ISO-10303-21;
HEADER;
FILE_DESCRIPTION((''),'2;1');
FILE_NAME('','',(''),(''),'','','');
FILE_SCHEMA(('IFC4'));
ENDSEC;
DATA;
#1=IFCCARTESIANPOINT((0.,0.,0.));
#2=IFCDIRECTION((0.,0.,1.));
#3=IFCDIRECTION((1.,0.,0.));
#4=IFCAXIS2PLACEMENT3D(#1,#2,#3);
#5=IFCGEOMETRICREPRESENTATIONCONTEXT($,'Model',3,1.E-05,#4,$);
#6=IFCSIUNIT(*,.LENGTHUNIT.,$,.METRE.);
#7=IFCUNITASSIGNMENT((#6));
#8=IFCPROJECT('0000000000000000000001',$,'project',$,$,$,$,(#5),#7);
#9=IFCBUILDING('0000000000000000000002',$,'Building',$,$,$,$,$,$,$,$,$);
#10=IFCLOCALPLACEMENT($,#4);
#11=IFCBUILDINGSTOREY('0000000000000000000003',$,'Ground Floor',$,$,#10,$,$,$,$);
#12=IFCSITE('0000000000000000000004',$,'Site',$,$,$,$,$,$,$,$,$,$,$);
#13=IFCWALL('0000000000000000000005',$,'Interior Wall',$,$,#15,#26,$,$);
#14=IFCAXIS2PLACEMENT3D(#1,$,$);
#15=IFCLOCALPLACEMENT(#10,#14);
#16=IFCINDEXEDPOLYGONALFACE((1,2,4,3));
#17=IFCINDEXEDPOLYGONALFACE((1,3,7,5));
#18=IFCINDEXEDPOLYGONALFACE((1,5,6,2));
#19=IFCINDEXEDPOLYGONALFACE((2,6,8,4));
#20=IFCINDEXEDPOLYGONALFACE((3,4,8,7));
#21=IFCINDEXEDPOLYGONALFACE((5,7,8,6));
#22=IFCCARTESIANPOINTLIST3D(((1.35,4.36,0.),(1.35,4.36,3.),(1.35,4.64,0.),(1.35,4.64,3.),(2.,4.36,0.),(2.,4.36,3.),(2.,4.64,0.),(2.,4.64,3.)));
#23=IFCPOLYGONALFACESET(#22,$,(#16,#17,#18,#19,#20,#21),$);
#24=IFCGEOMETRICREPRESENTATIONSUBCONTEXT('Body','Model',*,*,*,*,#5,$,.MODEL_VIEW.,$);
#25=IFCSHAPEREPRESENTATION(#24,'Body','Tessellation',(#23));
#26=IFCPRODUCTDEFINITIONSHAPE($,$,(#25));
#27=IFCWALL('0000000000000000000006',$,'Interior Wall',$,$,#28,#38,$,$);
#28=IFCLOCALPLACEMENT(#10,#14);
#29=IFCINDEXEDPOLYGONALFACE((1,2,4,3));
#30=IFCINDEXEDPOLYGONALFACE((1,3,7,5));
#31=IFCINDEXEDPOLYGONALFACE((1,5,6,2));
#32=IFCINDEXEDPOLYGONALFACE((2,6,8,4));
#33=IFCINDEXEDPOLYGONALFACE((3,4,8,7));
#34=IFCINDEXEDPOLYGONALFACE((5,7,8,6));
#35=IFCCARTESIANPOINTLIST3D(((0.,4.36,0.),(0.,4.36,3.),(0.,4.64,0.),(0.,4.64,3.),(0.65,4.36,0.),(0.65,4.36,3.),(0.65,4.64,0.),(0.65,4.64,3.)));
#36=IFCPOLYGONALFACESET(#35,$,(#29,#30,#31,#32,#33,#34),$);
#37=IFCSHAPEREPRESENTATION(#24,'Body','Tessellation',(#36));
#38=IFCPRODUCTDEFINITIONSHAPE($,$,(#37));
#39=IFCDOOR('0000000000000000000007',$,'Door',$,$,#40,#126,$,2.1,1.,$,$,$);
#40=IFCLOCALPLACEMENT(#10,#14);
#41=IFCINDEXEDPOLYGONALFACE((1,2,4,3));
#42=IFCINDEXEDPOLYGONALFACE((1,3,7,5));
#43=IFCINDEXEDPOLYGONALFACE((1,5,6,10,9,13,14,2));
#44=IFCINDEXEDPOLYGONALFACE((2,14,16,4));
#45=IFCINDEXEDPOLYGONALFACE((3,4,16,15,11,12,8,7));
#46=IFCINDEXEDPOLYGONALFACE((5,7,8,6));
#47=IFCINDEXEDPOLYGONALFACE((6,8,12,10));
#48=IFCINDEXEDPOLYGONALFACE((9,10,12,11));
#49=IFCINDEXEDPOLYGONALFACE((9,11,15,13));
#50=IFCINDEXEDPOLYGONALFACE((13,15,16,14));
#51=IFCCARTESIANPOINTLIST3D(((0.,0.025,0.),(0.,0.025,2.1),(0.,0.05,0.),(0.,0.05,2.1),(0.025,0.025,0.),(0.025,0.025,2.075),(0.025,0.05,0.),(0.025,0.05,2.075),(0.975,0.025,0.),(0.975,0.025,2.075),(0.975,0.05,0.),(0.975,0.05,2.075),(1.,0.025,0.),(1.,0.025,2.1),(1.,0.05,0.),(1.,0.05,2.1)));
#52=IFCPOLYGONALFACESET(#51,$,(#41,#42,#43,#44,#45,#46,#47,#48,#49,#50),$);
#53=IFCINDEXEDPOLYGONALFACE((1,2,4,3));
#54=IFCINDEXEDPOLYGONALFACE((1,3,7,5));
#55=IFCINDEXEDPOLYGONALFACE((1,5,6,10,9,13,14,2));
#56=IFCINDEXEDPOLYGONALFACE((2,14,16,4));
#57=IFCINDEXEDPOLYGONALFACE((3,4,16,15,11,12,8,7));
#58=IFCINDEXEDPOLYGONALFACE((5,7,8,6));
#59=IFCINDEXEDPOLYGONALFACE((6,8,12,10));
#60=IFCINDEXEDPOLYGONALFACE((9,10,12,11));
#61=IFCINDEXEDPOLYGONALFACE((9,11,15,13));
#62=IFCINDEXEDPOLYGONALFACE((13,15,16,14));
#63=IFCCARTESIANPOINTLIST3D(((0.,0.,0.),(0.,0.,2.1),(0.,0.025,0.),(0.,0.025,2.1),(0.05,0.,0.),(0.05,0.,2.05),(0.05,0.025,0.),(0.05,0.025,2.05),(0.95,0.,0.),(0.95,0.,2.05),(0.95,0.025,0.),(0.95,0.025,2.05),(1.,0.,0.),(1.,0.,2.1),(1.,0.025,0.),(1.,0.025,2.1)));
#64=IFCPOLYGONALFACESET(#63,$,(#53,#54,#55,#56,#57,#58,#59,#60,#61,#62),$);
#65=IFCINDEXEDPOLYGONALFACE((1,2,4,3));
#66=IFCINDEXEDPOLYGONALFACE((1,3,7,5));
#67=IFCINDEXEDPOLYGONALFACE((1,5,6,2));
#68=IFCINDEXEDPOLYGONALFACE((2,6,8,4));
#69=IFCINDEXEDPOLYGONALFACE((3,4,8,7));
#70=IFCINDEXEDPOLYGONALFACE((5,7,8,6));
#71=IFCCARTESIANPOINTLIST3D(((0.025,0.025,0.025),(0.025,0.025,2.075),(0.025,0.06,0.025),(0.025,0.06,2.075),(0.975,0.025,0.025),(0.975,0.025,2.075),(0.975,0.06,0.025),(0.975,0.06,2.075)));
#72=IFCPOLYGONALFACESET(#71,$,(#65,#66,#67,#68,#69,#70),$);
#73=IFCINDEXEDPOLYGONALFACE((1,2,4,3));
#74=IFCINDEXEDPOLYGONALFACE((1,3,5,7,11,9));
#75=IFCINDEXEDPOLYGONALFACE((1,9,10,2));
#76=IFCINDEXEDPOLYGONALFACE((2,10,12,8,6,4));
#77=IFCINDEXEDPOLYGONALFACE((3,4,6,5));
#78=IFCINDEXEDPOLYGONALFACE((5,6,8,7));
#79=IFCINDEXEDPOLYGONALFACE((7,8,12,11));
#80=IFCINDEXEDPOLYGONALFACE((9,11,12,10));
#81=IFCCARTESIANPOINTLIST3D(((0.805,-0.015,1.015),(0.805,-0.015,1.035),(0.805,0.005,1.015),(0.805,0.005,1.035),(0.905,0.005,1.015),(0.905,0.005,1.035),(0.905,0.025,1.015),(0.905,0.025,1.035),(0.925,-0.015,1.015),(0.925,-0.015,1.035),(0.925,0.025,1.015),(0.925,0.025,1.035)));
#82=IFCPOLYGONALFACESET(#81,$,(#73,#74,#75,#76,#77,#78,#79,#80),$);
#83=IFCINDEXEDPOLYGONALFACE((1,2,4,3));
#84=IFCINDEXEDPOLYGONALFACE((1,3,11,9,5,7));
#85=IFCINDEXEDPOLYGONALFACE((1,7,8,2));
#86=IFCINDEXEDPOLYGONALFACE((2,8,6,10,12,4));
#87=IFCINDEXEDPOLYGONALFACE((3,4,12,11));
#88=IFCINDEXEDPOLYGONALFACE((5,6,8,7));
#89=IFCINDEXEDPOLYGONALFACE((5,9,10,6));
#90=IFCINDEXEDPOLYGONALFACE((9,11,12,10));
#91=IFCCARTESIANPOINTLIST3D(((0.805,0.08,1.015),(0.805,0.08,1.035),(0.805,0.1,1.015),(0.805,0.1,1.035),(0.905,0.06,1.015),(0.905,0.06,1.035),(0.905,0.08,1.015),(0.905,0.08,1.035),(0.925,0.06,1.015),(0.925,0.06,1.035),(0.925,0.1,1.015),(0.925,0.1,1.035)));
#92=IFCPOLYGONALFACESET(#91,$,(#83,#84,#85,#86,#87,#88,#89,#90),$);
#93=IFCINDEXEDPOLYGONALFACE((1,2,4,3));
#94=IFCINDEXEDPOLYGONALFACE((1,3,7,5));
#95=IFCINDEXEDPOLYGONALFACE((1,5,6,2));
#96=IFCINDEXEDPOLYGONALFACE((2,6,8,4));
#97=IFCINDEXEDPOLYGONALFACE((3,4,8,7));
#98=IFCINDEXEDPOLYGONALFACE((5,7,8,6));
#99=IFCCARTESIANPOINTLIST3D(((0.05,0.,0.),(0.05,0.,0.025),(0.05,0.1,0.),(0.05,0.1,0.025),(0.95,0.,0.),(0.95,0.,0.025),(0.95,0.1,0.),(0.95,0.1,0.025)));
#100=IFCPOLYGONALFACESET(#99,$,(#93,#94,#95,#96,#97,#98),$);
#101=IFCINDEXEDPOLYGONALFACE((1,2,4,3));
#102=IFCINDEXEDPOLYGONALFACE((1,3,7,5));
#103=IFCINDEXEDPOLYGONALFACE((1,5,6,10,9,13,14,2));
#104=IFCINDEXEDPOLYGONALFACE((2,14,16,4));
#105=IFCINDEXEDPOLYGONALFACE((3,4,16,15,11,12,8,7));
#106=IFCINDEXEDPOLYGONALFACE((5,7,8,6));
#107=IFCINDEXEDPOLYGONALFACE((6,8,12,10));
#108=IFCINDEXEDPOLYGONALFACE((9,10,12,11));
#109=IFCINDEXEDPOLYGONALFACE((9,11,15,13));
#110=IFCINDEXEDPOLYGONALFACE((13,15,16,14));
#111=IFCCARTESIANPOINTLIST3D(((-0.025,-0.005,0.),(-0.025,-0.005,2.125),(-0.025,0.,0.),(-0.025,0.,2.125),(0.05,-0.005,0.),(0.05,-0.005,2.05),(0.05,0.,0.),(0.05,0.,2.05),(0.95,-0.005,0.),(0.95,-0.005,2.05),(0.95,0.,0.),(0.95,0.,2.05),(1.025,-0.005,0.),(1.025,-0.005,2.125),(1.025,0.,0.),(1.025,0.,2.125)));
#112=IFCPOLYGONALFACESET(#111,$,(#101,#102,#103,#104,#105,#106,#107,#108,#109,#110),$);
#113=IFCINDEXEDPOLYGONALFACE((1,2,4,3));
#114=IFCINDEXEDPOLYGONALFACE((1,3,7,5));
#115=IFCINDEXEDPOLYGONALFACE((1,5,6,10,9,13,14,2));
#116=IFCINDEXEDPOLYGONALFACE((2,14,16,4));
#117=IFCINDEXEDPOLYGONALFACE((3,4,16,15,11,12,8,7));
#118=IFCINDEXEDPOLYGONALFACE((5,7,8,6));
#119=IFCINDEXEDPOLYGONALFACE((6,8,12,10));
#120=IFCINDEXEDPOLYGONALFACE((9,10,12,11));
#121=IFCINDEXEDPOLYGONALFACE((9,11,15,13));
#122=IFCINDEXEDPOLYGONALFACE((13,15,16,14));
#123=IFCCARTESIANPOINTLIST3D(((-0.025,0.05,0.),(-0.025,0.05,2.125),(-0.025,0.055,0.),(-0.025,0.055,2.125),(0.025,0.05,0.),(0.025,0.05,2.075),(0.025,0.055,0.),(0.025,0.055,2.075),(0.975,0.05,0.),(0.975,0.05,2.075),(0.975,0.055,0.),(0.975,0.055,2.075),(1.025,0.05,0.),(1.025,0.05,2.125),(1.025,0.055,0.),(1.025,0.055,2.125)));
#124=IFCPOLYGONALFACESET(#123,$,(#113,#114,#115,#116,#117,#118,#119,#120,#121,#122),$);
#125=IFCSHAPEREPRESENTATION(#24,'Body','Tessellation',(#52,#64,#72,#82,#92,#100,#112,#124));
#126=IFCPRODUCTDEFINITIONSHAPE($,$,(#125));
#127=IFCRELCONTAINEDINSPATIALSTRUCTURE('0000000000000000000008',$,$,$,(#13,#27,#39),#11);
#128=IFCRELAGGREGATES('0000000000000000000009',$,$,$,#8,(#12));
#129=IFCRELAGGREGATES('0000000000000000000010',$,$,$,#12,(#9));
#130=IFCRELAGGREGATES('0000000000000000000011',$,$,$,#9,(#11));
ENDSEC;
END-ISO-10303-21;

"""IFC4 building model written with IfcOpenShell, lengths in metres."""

from ifc_helpers import new_model, si_unit, frame, origin_with_axes, place, context, subcontext, project, spatial, line, indexed_curve, outline, extrude, element, save


model = new_model("IFC4")

# Units and contexts
model_context = context("Model", 3, precision=1e-05, world=origin_with_axes())
body_context = subcontext(model_context, "Body", "Model", "MODEL_VIEW")
ifc_project = project(units=[si_unit("LENGTHUNIT", "METRE")], contexts=[model_context])

# Site, building, storey
site = spatial("IfcSite", under=ifc_project, Name="Site")
building = spatial("IfcBuilding", under=site, Name="Building")
storey_placement = place(None, origin_with_axes())
storey = spatial("IfcBuildingStorey", under=building, at=storey_placement, Name="Ground Floor")

# Walls
for number, where, z_axis, x_axis, name in (
    (1, (2.0, 4.5, 0.0), (0.0, 0.0, 1.0), (-1.0, 0.0, 0.0), "Interior Wall"),
    (2, (0.65, 4.5, 0.0), (0.0, 0.0, 1.0), (-1.0, 0.0, 0.0), "Interior Wall"),
):
    element("IfcWall", number, at=place(storey_placement, frame(where, z_axis=z_axis, x_axis=x_axis)), inside=storey, Name=name, context=body_context, shape_type="SweptSolid", body=[
        extrude(outline(indexed_curve([(0.0, 0.0), (0.0, 0.28), (0.65, 0.28), (0.65, 0.0), (0.0, 0.0)], self_intersect=False)), frame((0.0, -0.14, 0.0), z_axis=(0.0, 0.0, 1.0), x_axis=(1.0, 0.0, 0.0)), (0.0, 0.0, 1.0), 3.0),
    ])

# Door
door_1_placement = place(storey_placement, origin_with_axes())
element("IfcDoor", 3, at=door_1_placement, inside=storey, Name="Door", OverallHeight=2.1, OverallWidth=1.0, context=body_context, shape_type="SweptSolid", body=[
    extrude(outline(indexed_curve([(0.0, 0.0), (0.0, 2.1), (1.0, 2.1), (1.0, 0.0), (0.975, 0.0), (0.975, 2.075), (0.025, 2.075), (0.025, 0.0)], segments=[line(1, 2, 3, 4, 5, 6, 7, 8, 1)])), frame((0.0, 0.025, 0.0), z_axis=(0.0, -1.0, 0.0), x_axis=(1.0, 0.0, 0.0)), (0.0, 0.0, -1.0), 0.025),
    extrude(outline(indexed_curve([(0.0, 0.0), (0.0, 2.1), (1.0, 2.1), (1.0, 0.0), (0.95, 0.0), (0.95, 2.05), (0.05, 2.05), (0.05, 0.0)], segments=[line(1, 2, 3, 4, 5, 6, 7, 8, 1)])), frame((0.0, 0.0, 0.0), z_axis=(0.0, -1.0, 0.0), x_axis=(1.0, 0.0, 0.0)), (0.0, 0.0, -1.0), 0.025),
    extrude(outline(indexed_curve([(0.0, 0.0), (0.95, 0.0), (0.95, 0.035), (0.0, 0.035)], segments=[line(1, 2, 3, 4, 1)])), frame((0.025, 0.025, 0.025), z_axis=(0.0, 0.0, 1.0), x_axis=(1.0, 0.0, 0.0)), (0.0, 0.0, 1.0), 2.05),
    extrude(outline(indexed_curve([(0.0, 0.0), (0.0, -0.04), (-0.12, -0.04), (-0.12, -0.02), (-0.02, -0.02), (-0.02, 0.0)], segments=[line(1, 2, 3, 4, 5, 6, 1)])), frame((0.925, 0.025, 1.015), z_axis=(0.0, 0.0, 1.0), x_axis=(1.0, 0.0, 0.0)), (0.0, 0.0, 1.0), 0.02),
    extrude(outline(indexed_curve([(0.0, 0.0), (0.0, 0.04), (-0.12, 0.04), (-0.12, 0.02), (-0.02, 0.02), (-0.02, 0.0)], segments=[line(1, 2, 3, 4, 5, 6, 1)])), frame((0.925, 0.06, 1.015), z_axis=(0.0, 0.0, 1.0), x_axis=(1.0, 0.0, 0.0)), (0.0, 0.0, 1.0), 0.02),
    extrude(outline(indexed_curve([(0.0, 0.0), (0.9, 0.0), (0.9, 0.1), (0.0, 0.1)], segments=[line(1, 2, 3, 4, 1)])), frame((0.05, 0.0, 0.0), z_axis=(0.0, 0.0, 1.0), x_axis=(1.0, 0.0, 0.0)), (0.0, 0.0, 1.0), 0.025),
    extrude(outline(indexed_curve([(0.0, 0.0), (0.0, 2.125), (1.05, 2.125), (1.05, 0.0), (0.975, 0.0), (0.975, 2.05), (0.075, 2.05), (0.075, 0.0)], segments=[line(1, 2, 3, 4, 5, 6, 7, 8, 1)])), frame((-0.025, -0.005, 0.0), z_axis=(0.0, -1.0, 0.0), x_axis=(1.0, 0.0, 0.0)), (0.0, 0.0, -1.0), 0.005),
    extrude(outline(indexed_curve([(0.0, 0.0), (0.0, 2.125), (1.05, 2.125), (1.05, 0.0), (1.0, 0.0), (1.0, 2.075), (0.05, 2.075), (0.05, 0.0)], segments=[line(1, 2, 3, 4, 5, 6, 7, 8, 1)])), frame((-0.025, 0.05, 0.0), z_axis=(0.0, -1.0, 0.0), x_axis=(1.0, 0.0, 0.0)), (0.0, 0.0, -1.0), 0.005),
])

save(model, "model.ifc")
